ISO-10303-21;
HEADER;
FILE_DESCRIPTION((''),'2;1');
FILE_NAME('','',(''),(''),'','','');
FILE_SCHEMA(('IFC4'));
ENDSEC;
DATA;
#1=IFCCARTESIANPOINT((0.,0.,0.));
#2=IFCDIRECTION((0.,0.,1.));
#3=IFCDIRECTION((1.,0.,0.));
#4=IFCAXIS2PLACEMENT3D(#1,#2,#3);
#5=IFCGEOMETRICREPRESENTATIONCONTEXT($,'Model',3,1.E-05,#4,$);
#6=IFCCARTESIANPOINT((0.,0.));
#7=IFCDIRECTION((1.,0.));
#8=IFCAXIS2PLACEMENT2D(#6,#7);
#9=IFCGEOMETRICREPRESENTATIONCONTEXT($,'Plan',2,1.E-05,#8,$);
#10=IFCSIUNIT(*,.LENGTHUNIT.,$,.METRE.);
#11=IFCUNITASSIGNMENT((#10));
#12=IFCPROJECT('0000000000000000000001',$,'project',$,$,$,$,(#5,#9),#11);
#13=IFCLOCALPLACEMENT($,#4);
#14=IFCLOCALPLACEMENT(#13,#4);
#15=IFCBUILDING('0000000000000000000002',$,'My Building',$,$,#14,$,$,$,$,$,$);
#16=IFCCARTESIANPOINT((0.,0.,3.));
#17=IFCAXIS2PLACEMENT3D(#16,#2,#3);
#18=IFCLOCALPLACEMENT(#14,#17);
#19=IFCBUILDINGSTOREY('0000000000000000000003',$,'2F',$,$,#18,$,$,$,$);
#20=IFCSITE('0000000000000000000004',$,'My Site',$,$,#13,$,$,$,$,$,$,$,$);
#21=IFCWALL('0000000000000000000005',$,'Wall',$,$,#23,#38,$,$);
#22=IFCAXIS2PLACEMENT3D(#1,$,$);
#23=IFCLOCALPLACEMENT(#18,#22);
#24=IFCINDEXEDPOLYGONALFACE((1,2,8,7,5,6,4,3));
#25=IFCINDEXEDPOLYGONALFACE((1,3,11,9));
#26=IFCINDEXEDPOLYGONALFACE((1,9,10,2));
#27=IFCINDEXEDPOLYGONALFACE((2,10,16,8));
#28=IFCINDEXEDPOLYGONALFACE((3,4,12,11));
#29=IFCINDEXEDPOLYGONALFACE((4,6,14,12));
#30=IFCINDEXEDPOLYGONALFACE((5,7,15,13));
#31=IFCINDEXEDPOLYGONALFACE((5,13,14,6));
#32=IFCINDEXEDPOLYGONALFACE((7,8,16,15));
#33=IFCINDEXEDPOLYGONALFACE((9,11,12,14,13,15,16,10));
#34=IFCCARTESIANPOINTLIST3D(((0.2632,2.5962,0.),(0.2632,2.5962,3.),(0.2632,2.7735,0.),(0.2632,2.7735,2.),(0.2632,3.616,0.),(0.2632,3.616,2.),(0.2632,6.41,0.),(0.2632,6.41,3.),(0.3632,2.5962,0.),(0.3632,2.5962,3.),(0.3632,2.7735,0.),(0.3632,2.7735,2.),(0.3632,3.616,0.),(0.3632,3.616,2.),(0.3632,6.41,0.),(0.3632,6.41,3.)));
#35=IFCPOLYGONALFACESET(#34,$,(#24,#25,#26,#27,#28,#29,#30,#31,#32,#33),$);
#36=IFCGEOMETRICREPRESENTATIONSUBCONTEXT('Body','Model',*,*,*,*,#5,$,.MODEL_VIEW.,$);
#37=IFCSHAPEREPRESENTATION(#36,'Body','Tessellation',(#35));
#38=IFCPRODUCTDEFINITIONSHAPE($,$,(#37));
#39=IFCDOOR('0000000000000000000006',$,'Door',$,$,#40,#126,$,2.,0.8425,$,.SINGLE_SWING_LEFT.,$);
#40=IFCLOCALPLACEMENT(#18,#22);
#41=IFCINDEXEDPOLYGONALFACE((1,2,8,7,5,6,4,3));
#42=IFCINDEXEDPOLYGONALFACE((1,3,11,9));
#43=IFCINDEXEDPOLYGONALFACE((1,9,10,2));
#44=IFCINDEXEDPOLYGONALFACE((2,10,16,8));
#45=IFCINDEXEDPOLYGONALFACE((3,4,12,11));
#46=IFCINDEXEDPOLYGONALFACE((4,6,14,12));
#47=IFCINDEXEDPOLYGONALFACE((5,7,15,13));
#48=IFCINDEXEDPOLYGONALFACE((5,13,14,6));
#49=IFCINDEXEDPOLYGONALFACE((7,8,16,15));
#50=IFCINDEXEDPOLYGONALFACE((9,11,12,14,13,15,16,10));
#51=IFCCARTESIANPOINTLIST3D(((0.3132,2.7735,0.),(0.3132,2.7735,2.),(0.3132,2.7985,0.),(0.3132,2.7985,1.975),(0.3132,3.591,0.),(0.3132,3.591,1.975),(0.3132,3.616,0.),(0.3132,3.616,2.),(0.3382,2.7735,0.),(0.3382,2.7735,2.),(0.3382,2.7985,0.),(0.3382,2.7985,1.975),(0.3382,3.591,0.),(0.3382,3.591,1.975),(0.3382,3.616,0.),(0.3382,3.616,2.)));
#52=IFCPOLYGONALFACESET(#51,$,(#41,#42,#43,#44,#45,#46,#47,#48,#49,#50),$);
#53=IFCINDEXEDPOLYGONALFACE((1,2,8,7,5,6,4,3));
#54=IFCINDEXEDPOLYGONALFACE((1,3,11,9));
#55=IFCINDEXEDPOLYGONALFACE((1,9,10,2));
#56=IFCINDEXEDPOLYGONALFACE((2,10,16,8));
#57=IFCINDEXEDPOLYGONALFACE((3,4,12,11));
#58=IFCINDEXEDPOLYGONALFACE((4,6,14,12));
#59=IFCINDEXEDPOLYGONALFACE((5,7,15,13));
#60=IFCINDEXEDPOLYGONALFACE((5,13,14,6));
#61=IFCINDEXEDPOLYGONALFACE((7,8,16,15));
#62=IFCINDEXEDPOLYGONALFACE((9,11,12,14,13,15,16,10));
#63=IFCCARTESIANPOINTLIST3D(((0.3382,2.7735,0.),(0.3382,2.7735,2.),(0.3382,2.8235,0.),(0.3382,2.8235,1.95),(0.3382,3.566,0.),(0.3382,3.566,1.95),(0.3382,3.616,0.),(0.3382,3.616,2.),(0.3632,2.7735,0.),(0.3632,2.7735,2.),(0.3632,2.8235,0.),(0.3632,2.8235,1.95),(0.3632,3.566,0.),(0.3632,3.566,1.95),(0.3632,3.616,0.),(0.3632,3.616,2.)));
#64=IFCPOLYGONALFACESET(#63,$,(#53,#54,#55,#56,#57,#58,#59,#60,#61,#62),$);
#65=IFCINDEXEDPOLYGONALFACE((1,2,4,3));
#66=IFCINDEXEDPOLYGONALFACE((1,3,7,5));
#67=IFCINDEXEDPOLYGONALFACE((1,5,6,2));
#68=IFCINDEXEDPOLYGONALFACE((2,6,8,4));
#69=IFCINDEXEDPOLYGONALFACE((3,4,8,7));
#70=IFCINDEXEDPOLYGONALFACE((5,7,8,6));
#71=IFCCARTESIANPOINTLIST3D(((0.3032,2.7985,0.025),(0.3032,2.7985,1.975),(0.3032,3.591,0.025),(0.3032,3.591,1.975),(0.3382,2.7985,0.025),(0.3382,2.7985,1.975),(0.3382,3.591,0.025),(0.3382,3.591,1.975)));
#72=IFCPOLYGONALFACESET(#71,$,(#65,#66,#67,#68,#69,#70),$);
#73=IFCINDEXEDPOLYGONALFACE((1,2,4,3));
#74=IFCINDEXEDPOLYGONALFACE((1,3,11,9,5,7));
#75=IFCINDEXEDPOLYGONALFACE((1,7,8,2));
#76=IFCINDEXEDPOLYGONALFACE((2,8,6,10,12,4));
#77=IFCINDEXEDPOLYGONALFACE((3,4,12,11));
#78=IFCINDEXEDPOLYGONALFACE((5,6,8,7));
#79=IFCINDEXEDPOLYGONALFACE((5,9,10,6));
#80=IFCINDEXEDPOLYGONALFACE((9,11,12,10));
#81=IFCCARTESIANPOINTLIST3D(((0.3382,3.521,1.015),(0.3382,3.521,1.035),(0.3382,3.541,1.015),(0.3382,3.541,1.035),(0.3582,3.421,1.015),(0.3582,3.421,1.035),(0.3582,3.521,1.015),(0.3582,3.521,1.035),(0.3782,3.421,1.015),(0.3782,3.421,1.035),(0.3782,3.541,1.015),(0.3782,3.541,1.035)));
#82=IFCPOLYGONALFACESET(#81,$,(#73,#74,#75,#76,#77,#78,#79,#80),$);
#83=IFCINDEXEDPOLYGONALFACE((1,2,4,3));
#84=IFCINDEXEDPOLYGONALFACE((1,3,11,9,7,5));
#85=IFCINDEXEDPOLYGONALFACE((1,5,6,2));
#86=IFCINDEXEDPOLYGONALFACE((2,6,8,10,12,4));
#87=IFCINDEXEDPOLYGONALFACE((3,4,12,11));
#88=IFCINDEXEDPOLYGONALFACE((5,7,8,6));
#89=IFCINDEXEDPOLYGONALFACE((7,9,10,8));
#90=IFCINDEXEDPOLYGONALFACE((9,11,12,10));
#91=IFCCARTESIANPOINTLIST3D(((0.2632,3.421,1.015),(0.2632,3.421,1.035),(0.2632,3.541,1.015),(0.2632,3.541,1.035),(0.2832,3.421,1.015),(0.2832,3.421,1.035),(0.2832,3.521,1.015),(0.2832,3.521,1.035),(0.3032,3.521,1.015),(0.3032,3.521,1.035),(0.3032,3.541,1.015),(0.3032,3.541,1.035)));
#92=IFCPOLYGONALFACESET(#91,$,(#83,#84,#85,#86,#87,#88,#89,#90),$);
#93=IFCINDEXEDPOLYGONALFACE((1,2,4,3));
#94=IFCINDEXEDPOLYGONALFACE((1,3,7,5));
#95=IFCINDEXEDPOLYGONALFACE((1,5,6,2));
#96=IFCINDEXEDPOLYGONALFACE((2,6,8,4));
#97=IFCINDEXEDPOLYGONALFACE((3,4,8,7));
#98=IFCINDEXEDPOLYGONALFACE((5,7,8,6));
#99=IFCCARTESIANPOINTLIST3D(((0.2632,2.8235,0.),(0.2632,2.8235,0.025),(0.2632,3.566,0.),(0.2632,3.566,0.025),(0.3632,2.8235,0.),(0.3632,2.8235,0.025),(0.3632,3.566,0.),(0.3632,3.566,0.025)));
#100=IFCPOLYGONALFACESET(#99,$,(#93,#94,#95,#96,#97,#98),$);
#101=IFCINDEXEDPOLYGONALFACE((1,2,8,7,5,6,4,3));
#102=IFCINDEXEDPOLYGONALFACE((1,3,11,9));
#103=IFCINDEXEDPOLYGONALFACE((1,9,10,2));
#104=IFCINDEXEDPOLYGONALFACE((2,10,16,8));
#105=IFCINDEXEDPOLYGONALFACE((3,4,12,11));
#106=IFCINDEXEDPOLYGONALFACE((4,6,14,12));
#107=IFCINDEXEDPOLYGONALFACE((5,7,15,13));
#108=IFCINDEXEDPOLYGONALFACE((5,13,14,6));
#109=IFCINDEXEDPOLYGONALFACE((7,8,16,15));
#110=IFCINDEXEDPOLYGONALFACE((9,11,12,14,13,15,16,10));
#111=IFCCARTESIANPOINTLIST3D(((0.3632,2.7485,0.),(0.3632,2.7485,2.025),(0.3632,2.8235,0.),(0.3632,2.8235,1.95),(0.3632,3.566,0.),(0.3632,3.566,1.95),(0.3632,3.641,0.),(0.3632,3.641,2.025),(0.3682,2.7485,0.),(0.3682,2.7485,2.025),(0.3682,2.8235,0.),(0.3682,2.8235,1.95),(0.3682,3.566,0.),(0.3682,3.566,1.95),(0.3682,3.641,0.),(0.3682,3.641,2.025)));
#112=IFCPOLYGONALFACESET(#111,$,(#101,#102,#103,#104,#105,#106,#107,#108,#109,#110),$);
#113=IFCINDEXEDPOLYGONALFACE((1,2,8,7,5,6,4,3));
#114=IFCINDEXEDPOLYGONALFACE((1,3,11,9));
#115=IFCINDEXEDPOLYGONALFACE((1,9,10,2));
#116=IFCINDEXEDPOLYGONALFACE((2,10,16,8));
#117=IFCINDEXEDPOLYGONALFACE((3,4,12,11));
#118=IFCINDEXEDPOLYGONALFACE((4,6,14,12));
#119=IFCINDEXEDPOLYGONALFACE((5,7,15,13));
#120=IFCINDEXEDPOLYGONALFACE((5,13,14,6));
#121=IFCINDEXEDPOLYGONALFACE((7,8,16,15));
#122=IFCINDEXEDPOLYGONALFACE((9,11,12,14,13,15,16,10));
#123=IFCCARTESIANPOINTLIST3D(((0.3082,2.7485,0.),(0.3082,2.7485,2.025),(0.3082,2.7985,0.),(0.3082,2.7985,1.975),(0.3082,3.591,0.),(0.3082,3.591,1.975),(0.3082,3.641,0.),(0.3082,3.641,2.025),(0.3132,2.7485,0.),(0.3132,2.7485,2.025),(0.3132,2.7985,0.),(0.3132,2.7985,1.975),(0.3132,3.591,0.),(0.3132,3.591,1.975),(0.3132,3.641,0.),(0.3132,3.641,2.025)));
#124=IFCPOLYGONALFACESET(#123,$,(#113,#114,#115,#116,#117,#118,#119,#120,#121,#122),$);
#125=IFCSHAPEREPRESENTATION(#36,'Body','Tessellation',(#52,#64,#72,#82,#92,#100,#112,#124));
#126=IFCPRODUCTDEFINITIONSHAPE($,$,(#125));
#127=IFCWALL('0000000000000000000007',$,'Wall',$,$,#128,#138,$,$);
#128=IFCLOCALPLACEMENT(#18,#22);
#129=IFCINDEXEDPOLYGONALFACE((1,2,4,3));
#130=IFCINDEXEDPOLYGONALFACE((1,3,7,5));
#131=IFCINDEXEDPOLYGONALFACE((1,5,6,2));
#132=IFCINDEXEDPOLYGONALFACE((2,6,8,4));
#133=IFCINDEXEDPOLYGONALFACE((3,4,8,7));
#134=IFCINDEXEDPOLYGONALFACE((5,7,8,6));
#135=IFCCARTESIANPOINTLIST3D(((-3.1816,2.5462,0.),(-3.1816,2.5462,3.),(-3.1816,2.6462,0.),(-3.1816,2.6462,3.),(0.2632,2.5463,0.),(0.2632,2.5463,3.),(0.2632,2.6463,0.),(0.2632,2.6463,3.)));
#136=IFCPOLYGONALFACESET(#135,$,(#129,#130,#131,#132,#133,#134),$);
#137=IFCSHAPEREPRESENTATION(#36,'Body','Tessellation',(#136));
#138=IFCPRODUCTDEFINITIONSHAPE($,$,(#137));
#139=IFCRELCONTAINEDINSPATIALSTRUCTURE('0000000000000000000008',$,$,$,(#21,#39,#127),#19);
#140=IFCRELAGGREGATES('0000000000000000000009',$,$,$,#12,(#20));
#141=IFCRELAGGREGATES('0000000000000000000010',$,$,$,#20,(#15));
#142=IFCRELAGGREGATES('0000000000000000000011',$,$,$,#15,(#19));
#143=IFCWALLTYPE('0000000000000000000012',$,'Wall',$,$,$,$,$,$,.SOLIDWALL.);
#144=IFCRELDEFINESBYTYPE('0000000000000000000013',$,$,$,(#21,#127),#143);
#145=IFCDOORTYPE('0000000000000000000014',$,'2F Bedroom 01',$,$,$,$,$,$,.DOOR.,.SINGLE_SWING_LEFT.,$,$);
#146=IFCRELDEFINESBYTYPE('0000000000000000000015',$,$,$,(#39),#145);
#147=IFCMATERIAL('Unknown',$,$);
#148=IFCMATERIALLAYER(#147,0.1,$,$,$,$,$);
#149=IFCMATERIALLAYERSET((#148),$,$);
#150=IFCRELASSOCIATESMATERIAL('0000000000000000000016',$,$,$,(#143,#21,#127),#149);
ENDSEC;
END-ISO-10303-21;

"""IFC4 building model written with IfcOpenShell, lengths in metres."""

from ifc_helpers import new_model, entity, si_unit, frame, origin_with_axes, origin_2d_with_axis, place, context, subcontext, project, spatial, line, indexed_curve, outline, extrude, shape, source, transform, mapped, material, layer, layer_set, layer_usage, type_object, type_shapes, element, fill, save


model = new_model("IFC4")

# Units and contexts
model_context_1 = context("Model", 3, precision=1e-05, world=origin_with_axes())
plan_context = context("Plan", 2, precision=1e-05, world=origin_2d_with_axis())
body_context_1 = subcontext(model_context_1, "Body", "Model", "MODEL_VIEW")
body_context_2 = subcontext(plan_context, "Body", "Plan", "PLAN_VIEW")
ifc_project = project(units=[si_unit("LENGTHUNIT", "METRE")], contexts=[model_context_1, plan_context])

# Site, building, storey
site_placement = place(None, origin_with_axes())
site = spatial("IfcSite", under=ifc_project, at=site_placement, Name="My Site")
building_placement = place(site_placement, origin_with_axes())
building = spatial("IfcBuilding", under=site, at=building_placement, Name="My Building")
storey_placement = place(building_placement, frame((0.0, 0.0, 3.0), z_axis=(0.0, 0.0, 1.0), x_axis=(1.0, 0.0, 0.0)))
storey = spatial("IfcBuildingStorey", under=building, at=storey_placement, Name="2F")

# Shared definitions
ifc_material = material(Name="Unknown")

# Shared definitions
ifc_layer_1 = layer(ifc_material, 0.1)
ifc_layer_set_1 = layer_set([ifc_layer_1])
wall_type = type_object("IfcWallType", Name="Wall", PredefinedType="SOLIDWALL", material=ifc_layer_set_1)

# Wall, opening, door
ifc_layer_usage_1 = layer_usage(ifc_layer_set_1, "AXIS2", "POSITIVE", 0.0)
wall_1_placement = place(storey_placement, frame((0.2632, 6.51, 0.0), z_axis=(0.0, 0.0, 1.0), x_axis=(0.0, -1.0, 0.0)))
wall_1 = element("IfcWall", 1, at=wall_1_placement, inside=storey, type_object=wall_type, material=ifc_layer_usage_1, Name="Wall", context=body_context_1, shape_type="SweptSolid", body=[
    extrude(outline(indexed_curve([(0.1, 0.0), (0.1, 0.1), (3.9137, 0.1), (3.9137, 0.0)], segments=[line(1, 2, 3, 4, 1)])), origin_with_axes(), (0.0, 0.0, 1.0), 3.0),
])
shared_shape_1 = source(origin_with_axes(), body_context_1, "Body", "SweptSolid", [
    extrude(outline(indexed_curve([(0.0, 0.0), (0.8425, 0.0), (0.8425, 2.0), (0.0, 2.0)], segments=[line(1, 2, 3, 4, 1)])), frame((0.0, -0.6, 0.0), z_axis=(0.0, -1.0, 0.0), x_axis=(1.0, 0.0, 0.0)), (0.0, 0.0, -1.0), 1.2),
])
opening_1_placement = place(wall_1_placement, frame((3.7364, 0.1, 0.0), z_axis=(0.0, 0.0, 1.0), x_axis=(-1.0, 0.0, 0.0)))
opening_1 = element("IfcOpeningElement", 2, at=opening_1_placement, cuts=wall_1, PredefinedType="OPENING", context=body_context_1, shape_type="MappedRepresentation", body=[
    mapped(shared_shape_1, transform((0.0, 0.0, 0.0), x_axis=(1.0, 0.0, 0.0), y_axis=(0.0, 1.0, 0.0), z_axis=(0.0, 0.0, 1.0), scale=1.0)),
])
door_type_1 = type_object("IfcDoorType", Name="2F Bedroom 01", OperationType="SINGLE_SWING_LEFT", PredefinedType="DOOR")
shared_shape_2 = source(origin_with_axes(), body_context_1, "Body", "SweptSolid", [
    extrude(outline(indexed_curve([(0.0, 0.0), (0.0, 2.0), (0.8425, 2.0), (0.8425, 0.0), (0.8175, 0.0), (0.8175, 1.975), (0.025, 1.975), (0.025, 0.0)], segments=[line(1, 2, 3, 4, 5, 6, 7, 8, 1)])), frame((0.0, 0.025, 0.0), z_axis=(0.0, -1.0, 0.0), x_axis=(1.0, 0.0, 0.0)), (0.0, 0.0, -1.0), 0.025),
    extrude(outline(indexed_curve([(0.0, 0.0), (0.0, 2.0), (0.8425, 2.0), (0.8425, 0.0), (0.7925, 0.0), (0.7925, 1.95), (0.05, 1.95), (0.05, 0.0)], segments=[line(1, 2, 3, 4, 5, 6, 7, 8, 1)])), frame((0.0, 0.0, 0.0), z_axis=(0.0, -1.0, 0.0), x_axis=(1.0, 0.0, 0.0)), (0.0, 0.0, -1.0), 0.025),
    extrude(outline(indexed_curve([(0.0, 0.0), (0.7925, 0.0), (0.7925, 0.035), (0.0, 0.035)], segments=[line(1, 2, 3, 4, 1)])), frame((0.025, 0.025, 0.025), z_axis=(0.0, 0.0, 1.0), x_axis=(1.0, 0.0, 0.0)), (0.0, 0.0, 1.0), 1.95),
    extrude(outline(indexed_curve([(0.0, 0.0), (0.0, -0.04), (-0.12, -0.04), (-0.12, -0.02), (-0.02, -0.02), (-0.02, 0.0)], segments=[line(1, 2, 3, 4, 5, 6, 1)])), frame((0.7675, 0.025, 1.015), z_axis=(0.0, 0.0, 1.0), x_axis=(1.0, 0.0, 0.0)), (0.0, 0.0, 1.0), 0.02),
    extrude(outline(indexed_curve([(0.0, 0.0), (0.0, 0.04), (-0.12, 0.04), (-0.12, 0.02), (-0.02, 0.02), (-0.02, 0.0)], segments=[line(1, 2, 3, 4, 5, 6, 1)])), frame((0.7675, 0.06, 1.015), z_axis=(0.0, 0.0, 1.0), x_axis=(1.0, 0.0, 0.0)), (0.0, 0.0, 1.0), 0.02),
    extrude(outline(indexed_curve([(0.0, 0.0), (0.7425, 0.0), (0.7425, 0.1), (0.0, 0.1)], segments=[line(1, 2, 3, 4, 1)])), frame((0.05, 0.0, 0.0), z_axis=(0.0, 0.0, 1.0), x_axis=(1.0, 0.0, 0.0)), (0.0, 0.0, 1.0), 0.025),
    extrude(outline(indexed_curve([(0.0, 0.0), (0.0, 2.025), (0.8925, 2.025), (0.8925, 0.0), (0.8175, 0.0), (0.8175, 1.95), (0.075, 1.95), (0.075, 0.0)], segments=[line(1, 2, 3, 4, 5, 6, 7, 8, 1)])), frame((-0.025, -0.005, 0.0), z_axis=(0.0, -1.0, 0.0), x_axis=(1.0, 0.0, 0.0)), (0.0, 0.0, -1.0), 0.005),
    extrude(outline(indexed_curve([(0.0, 0.0), (0.0, 2.025), (0.8925, 2.025), (0.8925, 0.0), (0.8425, 0.0), (0.8425, 1.975), (0.05, 1.975), (0.05, 0.0)], segments=[line(1, 2, 3, 4, 5, 6, 7, 8, 1)])), frame((-0.025, 0.05, 0.0), z_axis=(0.0, -1.0, 0.0), x_axis=(1.0, 0.0, 0.0)), (0.0, 0.0, -1.0), 0.005),
])
shared_shape_3 = source(origin_with_axes(), body_context_2, "Body", "Curve2D", [
    entity("IfcIndexedPolyCurve", entity("IfcCartesianPointList2D", [[0.0, 0.0], [0.0, 0.05], [0.025, 0.05], [0.025, 0.025], [0.05, 0.025], [0.05, 0.0]]), [entity("IfcLineIndex", [1, 2, 3, 4, 5, 6, 1])]),
    entity("IfcIndexedPolyCurve", entity("IfcCartesianPointList2D", [[0.8425, 0.0], [0.8425, 0.05], [0.8175, 0.05], [0.8175, 0.025], [0.7925, 0.025], [0.7925, 0.0]]), [entity("IfcLineIndex", [1, 2, 3, 4, 5, 6, 1])]),
    entity("IfcTrimmedCurve", entity("IfcEllipse", entity("IfcAxis2Placement2D", entity("IfcCartesianPoint", [0.06, 0.05]), entity("IfcDirection", [1.0, 0.0])), 0.7575, 0.7925), [entity("IfcCartesianPoint", [0.8175, 0.05])], [entity("IfcCartesianPoint", [0.06, 0.8425])], True, "CARTESIAN"),
    entity("IfcIndexedPolyCurve", entity("IfcCartesianPointList2D", [[0.025, 0.05], [0.06, 0.05], [0.06, 0.8425], [0.025, 0.8425]]), [entity("IfcLineIndex", [1, 2, 3, 4, 1])]),
])
type_shapes(door_type_1, [shared_shape_2, shared_shape_3])
door_1_placement = place(opening_1_placement, frame((0.0, 0.0, 0.0), z_axis=(0.0, 0.0, 1.0), x_axis=(1.0, 0.0, 0.0)))
door_1 = element("IfcDoor", 3, at=door_1_placement, inside=storey, type_object=door_type_1, Name="Door", OperationType="SINGLE_SWING_LEFT", OverallHeight=2.0, OverallWidth=0.8425, shapes=[
    shape(body_context_1, "Body", "MappedRepresentation", [mapped(shared_shape_2, transform((0.0, 0.0, 0.0), x_axis=(1.0, 0.0, 0.0), y_axis=(0.0, 1.0, 0.0), z_axis=(0.0, 0.0, 1.0), scale=1.0))]),
    shape(body_context_2, "Body", "MappedRepresentation", [mapped(shared_shape_3, transform((0.0, 0.0, 0.0), x_axis=(1.0, 0.0, 0.0), y_axis=(0.0, 1.0, 0.0), z_axis=(0.0, 0.0, 1.0), scale=1.0))]),
])
fill(opening_1, door_1)

# Wall
ifc_layer_usage_2 = layer_usage(ifc_layer_set_1, "AXIS2", "POSITIVE", 0.0)
wall_2_placement = place(storey_placement, frame((0.2632, 2.6463, 0.0), z_axis=(0.0, 0.0, 1.0), x_axis=(-1.0, 0.0, 0.0)))
element("IfcWall", 4, at=wall_2_placement, inside=storey, type_object=wall_type, material=ifc_layer_usage_2, Name="Wall", context=body_context_1, shape_type="SweptSolid", body=[
    extrude(outline(indexed_curve([(0.0, 0.0), (0.0, 0.1), (3.4448, 0.1), (3.4448, 0.0)], segments=[line(1, 2, 3, 4, 1)])), origin_with_axes(), (0.0, 0.0, 1.0), 3.0),
])

save(model, "model.ifc")
